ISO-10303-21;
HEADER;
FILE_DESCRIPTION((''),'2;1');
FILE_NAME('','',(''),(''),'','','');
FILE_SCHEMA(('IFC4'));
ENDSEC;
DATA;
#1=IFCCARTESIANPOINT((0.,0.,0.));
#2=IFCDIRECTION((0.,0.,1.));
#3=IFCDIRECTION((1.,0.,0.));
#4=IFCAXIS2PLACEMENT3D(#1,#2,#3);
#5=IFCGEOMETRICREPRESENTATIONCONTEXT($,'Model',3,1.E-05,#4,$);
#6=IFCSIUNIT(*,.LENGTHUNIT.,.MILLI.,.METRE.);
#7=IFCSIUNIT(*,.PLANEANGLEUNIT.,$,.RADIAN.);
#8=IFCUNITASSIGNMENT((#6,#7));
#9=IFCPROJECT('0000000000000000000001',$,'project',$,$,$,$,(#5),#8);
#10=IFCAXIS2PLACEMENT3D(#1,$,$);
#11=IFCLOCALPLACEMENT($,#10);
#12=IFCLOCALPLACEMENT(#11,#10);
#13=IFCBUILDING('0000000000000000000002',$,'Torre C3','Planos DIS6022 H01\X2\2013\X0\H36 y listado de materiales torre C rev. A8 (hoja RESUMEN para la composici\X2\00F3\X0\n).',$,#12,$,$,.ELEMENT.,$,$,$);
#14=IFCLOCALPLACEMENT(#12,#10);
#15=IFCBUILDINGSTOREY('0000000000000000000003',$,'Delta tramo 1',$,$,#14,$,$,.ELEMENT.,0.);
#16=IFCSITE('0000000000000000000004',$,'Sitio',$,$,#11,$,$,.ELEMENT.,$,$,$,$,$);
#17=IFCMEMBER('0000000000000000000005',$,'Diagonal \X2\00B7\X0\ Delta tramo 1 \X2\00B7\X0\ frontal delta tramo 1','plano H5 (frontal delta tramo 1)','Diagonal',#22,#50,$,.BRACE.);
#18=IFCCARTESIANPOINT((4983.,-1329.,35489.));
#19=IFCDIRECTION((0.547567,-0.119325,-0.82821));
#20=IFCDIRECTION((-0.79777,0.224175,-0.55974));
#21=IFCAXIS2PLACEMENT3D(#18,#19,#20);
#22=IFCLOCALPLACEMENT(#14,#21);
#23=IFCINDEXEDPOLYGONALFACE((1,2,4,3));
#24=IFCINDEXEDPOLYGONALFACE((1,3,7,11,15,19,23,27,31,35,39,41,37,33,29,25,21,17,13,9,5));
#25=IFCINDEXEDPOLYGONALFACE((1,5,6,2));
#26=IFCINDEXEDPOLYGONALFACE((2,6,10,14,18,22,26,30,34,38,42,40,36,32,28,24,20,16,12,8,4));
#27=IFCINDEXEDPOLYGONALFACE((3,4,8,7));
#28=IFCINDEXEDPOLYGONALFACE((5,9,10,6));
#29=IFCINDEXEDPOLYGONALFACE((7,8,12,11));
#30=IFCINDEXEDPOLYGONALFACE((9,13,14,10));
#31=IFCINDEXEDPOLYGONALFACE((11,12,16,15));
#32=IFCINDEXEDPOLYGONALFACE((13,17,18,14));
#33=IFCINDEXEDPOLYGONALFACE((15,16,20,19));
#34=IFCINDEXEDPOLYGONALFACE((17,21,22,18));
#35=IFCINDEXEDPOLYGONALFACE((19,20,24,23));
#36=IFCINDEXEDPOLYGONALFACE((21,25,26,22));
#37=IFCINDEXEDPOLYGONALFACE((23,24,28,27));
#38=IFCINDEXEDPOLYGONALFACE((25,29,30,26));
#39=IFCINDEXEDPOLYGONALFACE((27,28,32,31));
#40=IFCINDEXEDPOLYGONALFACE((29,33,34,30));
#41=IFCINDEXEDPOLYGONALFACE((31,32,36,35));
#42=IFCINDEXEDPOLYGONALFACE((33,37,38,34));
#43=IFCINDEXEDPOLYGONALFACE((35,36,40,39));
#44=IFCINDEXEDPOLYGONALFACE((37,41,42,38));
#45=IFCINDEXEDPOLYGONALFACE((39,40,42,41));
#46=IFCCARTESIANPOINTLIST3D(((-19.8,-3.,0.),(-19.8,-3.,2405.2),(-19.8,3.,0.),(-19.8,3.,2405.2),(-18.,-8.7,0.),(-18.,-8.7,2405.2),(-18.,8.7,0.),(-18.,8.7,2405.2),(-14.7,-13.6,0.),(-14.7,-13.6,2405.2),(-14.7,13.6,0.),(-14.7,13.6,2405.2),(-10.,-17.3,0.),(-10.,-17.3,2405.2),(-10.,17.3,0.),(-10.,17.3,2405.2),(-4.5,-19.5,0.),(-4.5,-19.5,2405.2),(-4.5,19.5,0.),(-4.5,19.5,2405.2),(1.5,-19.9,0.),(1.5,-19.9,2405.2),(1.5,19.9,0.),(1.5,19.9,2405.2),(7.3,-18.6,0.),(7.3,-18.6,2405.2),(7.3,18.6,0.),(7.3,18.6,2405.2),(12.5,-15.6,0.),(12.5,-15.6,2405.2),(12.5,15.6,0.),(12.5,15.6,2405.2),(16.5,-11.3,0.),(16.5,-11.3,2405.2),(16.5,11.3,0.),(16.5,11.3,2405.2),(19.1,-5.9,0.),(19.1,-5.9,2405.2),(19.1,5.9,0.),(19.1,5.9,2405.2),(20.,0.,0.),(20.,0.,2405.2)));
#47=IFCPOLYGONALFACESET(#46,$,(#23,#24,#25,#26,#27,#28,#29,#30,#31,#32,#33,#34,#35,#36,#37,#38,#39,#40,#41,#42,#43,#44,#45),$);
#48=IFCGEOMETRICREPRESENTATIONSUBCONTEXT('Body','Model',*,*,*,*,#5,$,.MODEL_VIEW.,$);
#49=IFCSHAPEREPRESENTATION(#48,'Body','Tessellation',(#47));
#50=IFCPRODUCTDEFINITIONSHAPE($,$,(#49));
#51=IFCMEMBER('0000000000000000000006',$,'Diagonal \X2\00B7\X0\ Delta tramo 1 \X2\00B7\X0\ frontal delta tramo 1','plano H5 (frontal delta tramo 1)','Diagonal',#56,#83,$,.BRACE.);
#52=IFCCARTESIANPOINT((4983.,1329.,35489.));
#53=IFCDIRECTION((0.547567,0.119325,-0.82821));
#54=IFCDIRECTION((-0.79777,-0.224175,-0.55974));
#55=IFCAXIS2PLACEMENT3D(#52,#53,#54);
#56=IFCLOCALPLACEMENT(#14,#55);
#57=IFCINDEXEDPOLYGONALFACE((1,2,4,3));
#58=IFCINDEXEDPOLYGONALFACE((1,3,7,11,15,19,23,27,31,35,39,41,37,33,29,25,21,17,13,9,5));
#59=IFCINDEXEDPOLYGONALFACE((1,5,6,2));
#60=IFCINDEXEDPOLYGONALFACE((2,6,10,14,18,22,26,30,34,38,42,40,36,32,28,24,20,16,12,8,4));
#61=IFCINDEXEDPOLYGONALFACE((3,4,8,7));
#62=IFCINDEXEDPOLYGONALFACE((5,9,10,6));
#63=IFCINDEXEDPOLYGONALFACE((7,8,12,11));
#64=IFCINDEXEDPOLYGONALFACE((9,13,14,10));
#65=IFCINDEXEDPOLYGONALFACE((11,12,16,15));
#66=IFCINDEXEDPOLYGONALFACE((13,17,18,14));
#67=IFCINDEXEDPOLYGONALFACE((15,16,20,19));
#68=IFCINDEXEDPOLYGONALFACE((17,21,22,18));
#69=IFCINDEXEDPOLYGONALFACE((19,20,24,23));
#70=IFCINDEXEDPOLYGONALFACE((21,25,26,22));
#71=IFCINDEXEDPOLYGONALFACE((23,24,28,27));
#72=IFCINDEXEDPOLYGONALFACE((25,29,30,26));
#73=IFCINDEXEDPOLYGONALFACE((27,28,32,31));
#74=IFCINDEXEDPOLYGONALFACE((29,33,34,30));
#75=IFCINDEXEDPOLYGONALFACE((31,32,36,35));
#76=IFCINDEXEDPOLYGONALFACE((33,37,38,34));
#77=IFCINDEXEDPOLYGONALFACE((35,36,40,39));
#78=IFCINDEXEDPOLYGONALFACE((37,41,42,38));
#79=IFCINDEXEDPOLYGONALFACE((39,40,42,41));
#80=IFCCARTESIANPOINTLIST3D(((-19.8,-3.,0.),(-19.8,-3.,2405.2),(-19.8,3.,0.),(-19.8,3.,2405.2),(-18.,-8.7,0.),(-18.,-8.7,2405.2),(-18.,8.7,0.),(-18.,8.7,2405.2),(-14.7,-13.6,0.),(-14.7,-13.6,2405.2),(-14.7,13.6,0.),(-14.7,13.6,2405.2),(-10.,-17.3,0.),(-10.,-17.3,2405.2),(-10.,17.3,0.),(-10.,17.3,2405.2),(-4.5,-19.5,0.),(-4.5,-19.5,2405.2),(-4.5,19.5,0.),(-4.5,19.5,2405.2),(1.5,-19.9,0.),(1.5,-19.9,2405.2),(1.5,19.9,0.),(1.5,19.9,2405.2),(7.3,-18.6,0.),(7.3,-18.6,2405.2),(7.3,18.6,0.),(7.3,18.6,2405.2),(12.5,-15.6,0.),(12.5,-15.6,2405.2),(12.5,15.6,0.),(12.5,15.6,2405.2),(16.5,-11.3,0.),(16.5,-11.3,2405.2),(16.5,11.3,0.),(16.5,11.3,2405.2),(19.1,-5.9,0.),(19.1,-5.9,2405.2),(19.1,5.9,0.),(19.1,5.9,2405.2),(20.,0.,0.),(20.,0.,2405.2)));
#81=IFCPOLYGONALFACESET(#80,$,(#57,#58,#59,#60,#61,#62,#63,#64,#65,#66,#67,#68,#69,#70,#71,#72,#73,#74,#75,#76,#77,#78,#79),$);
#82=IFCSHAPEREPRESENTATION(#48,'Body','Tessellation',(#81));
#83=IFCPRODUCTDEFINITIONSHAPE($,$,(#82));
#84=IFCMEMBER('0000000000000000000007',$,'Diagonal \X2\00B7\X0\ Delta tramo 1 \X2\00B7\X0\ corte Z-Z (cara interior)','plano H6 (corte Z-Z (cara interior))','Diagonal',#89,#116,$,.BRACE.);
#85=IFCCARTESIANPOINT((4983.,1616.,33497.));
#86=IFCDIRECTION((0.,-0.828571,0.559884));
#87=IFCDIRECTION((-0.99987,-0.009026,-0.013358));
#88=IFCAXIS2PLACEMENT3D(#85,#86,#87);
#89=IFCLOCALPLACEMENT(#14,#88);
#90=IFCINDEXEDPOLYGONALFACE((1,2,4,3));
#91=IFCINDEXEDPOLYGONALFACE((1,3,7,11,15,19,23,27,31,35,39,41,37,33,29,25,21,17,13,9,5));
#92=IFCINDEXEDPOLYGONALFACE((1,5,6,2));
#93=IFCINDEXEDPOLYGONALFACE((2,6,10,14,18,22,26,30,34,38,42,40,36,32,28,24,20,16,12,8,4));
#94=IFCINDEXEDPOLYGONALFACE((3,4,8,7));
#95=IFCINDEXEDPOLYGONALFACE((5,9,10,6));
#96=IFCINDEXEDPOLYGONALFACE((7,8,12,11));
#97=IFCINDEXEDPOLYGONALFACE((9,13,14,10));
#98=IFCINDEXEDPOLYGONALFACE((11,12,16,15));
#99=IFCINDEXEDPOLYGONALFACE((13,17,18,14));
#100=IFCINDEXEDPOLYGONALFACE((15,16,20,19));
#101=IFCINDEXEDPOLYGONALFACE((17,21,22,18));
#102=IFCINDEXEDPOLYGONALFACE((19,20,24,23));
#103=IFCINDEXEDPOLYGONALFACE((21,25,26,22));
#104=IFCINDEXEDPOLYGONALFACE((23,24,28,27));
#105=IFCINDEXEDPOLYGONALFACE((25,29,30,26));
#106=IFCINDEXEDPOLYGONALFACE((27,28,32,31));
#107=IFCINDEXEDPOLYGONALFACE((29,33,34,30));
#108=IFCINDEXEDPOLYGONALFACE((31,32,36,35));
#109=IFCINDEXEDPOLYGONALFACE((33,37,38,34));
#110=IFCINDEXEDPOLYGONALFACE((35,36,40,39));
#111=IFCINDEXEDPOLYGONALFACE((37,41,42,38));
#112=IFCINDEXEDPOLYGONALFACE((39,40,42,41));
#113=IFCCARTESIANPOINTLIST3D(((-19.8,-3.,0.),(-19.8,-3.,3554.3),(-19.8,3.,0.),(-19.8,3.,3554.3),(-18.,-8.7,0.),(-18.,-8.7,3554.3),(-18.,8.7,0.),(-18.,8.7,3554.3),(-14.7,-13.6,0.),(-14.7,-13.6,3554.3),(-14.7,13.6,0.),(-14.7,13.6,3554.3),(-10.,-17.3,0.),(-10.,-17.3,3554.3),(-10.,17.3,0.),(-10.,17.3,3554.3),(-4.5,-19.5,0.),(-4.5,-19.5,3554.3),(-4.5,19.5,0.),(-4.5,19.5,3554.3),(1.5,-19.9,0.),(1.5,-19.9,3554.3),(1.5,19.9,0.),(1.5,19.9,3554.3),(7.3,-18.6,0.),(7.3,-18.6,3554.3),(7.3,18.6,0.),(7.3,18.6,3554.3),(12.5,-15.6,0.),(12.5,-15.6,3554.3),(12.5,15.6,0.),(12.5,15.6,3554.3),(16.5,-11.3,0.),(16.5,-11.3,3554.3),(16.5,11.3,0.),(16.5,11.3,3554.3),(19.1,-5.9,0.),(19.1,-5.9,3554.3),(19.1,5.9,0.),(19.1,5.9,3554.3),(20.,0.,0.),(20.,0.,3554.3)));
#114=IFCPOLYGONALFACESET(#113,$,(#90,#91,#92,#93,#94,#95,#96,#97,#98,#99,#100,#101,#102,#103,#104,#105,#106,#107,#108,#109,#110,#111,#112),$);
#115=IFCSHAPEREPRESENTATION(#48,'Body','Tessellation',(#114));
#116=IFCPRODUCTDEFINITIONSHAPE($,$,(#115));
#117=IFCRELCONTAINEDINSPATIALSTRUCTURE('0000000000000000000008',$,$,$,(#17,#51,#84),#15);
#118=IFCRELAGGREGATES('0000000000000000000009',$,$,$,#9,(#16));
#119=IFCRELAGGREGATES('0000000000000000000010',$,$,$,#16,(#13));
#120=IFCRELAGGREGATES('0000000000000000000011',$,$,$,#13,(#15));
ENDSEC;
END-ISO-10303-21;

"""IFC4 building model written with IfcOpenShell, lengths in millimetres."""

from ifc_helpers import new_model, si_unit, frame, origin, origin_with_axes, place, context, subcontext, project, spatial, circle, extrude, element, save


model = new_model("IFC4")

# Units and contexts
model_context = context("Model", 3, precision=1e-05, world=origin_with_axes())
body_context = subcontext(model_context, "Body", "Model", "MODEL_VIEW")
ifc_project = project(units=[si_unit("LENGTHUNIT", "METRE", prefix="MILLI"), si_unit("PLANEANGLEUNIT", "RADIAN")], contexts=[model_context])

# Site, building, storey
site_placement = place(None, origin())
site = spatial("IfcSite", under=ifc_project, at=site_placement, Name="Sitio", CompositionType="ELEMENT")
building_placement = place(site_placement, origin())
building = spatial("IfcBuilding", under=site, at=building_placement, Name="Torre C3", Description="Planos DIS6022 H01–H36 y listado de materiales torre C rev. A8 (hoja RESUMEN para la composición).", CompositionType="ELEMENT")
storey_placement = place(building_placement, origin())
storey = spatial("IfcBuildingStorey", under=building, at=storey_placement, Name="Delta tramo 1", CompositionType="ELEMENT", Elevation=0.0)

# Members
for number, where, z_axis, x_axis, name in (
    (1, (4983.0, -1329.0, 35489.0), (0.547567, -0.119325, -0.82821), (-0.79777, 0.224175, -0.55974), "Diagonal · Delta tramo 1 · frontal delta tramo 1"),
    (2, (4983.0, 1329.0, 35489.0), (0.547567, 0.119325, -0.82821), (-0.79777, -0.224175, -0.55974), "Diagonal · Delta tramo 1 · frontal delta tramo 1"),
):
    element("IfcMember", number, at=place(storey_placement, frame(where, z_axis=z_axis, x_axis=x_axis)), inside=storey, Name=name, Description="plano H5 (frontal delta tramo 1)", ObjectType="Diagonal", PredefinedType="BRACE", context=body_context, shape_type="SweptSolid", body=[
        extrude(circle(Radius=20.0), None, (0.0, 0.0, 1.0), 2405.2),
    ])
member_1_placement = place(storey_placement, frame((4983.0, 1616.0, 33497.0), z_axis=(0.0, -0.828571, 0.559884), x_axis=(-0.99987, -0.009026, -0.013358)))
element("IfcMember", 3, at=member_1_placement, inside=storey, Name="Diagonal · Delta tramo 1 · corte Z-Z (cara interior)", Description="plano H6 (corte Z-Z (cara interior))", ObjectType="Diagonal", PredefinedType="BRACE", context=body_context, shape_type="SweptSolid", body=[
    extrude(circle(Radius=20.0), None, (0.0, 0.0, 1.0), 3554.3),
])

save(model, "model.ifc")
